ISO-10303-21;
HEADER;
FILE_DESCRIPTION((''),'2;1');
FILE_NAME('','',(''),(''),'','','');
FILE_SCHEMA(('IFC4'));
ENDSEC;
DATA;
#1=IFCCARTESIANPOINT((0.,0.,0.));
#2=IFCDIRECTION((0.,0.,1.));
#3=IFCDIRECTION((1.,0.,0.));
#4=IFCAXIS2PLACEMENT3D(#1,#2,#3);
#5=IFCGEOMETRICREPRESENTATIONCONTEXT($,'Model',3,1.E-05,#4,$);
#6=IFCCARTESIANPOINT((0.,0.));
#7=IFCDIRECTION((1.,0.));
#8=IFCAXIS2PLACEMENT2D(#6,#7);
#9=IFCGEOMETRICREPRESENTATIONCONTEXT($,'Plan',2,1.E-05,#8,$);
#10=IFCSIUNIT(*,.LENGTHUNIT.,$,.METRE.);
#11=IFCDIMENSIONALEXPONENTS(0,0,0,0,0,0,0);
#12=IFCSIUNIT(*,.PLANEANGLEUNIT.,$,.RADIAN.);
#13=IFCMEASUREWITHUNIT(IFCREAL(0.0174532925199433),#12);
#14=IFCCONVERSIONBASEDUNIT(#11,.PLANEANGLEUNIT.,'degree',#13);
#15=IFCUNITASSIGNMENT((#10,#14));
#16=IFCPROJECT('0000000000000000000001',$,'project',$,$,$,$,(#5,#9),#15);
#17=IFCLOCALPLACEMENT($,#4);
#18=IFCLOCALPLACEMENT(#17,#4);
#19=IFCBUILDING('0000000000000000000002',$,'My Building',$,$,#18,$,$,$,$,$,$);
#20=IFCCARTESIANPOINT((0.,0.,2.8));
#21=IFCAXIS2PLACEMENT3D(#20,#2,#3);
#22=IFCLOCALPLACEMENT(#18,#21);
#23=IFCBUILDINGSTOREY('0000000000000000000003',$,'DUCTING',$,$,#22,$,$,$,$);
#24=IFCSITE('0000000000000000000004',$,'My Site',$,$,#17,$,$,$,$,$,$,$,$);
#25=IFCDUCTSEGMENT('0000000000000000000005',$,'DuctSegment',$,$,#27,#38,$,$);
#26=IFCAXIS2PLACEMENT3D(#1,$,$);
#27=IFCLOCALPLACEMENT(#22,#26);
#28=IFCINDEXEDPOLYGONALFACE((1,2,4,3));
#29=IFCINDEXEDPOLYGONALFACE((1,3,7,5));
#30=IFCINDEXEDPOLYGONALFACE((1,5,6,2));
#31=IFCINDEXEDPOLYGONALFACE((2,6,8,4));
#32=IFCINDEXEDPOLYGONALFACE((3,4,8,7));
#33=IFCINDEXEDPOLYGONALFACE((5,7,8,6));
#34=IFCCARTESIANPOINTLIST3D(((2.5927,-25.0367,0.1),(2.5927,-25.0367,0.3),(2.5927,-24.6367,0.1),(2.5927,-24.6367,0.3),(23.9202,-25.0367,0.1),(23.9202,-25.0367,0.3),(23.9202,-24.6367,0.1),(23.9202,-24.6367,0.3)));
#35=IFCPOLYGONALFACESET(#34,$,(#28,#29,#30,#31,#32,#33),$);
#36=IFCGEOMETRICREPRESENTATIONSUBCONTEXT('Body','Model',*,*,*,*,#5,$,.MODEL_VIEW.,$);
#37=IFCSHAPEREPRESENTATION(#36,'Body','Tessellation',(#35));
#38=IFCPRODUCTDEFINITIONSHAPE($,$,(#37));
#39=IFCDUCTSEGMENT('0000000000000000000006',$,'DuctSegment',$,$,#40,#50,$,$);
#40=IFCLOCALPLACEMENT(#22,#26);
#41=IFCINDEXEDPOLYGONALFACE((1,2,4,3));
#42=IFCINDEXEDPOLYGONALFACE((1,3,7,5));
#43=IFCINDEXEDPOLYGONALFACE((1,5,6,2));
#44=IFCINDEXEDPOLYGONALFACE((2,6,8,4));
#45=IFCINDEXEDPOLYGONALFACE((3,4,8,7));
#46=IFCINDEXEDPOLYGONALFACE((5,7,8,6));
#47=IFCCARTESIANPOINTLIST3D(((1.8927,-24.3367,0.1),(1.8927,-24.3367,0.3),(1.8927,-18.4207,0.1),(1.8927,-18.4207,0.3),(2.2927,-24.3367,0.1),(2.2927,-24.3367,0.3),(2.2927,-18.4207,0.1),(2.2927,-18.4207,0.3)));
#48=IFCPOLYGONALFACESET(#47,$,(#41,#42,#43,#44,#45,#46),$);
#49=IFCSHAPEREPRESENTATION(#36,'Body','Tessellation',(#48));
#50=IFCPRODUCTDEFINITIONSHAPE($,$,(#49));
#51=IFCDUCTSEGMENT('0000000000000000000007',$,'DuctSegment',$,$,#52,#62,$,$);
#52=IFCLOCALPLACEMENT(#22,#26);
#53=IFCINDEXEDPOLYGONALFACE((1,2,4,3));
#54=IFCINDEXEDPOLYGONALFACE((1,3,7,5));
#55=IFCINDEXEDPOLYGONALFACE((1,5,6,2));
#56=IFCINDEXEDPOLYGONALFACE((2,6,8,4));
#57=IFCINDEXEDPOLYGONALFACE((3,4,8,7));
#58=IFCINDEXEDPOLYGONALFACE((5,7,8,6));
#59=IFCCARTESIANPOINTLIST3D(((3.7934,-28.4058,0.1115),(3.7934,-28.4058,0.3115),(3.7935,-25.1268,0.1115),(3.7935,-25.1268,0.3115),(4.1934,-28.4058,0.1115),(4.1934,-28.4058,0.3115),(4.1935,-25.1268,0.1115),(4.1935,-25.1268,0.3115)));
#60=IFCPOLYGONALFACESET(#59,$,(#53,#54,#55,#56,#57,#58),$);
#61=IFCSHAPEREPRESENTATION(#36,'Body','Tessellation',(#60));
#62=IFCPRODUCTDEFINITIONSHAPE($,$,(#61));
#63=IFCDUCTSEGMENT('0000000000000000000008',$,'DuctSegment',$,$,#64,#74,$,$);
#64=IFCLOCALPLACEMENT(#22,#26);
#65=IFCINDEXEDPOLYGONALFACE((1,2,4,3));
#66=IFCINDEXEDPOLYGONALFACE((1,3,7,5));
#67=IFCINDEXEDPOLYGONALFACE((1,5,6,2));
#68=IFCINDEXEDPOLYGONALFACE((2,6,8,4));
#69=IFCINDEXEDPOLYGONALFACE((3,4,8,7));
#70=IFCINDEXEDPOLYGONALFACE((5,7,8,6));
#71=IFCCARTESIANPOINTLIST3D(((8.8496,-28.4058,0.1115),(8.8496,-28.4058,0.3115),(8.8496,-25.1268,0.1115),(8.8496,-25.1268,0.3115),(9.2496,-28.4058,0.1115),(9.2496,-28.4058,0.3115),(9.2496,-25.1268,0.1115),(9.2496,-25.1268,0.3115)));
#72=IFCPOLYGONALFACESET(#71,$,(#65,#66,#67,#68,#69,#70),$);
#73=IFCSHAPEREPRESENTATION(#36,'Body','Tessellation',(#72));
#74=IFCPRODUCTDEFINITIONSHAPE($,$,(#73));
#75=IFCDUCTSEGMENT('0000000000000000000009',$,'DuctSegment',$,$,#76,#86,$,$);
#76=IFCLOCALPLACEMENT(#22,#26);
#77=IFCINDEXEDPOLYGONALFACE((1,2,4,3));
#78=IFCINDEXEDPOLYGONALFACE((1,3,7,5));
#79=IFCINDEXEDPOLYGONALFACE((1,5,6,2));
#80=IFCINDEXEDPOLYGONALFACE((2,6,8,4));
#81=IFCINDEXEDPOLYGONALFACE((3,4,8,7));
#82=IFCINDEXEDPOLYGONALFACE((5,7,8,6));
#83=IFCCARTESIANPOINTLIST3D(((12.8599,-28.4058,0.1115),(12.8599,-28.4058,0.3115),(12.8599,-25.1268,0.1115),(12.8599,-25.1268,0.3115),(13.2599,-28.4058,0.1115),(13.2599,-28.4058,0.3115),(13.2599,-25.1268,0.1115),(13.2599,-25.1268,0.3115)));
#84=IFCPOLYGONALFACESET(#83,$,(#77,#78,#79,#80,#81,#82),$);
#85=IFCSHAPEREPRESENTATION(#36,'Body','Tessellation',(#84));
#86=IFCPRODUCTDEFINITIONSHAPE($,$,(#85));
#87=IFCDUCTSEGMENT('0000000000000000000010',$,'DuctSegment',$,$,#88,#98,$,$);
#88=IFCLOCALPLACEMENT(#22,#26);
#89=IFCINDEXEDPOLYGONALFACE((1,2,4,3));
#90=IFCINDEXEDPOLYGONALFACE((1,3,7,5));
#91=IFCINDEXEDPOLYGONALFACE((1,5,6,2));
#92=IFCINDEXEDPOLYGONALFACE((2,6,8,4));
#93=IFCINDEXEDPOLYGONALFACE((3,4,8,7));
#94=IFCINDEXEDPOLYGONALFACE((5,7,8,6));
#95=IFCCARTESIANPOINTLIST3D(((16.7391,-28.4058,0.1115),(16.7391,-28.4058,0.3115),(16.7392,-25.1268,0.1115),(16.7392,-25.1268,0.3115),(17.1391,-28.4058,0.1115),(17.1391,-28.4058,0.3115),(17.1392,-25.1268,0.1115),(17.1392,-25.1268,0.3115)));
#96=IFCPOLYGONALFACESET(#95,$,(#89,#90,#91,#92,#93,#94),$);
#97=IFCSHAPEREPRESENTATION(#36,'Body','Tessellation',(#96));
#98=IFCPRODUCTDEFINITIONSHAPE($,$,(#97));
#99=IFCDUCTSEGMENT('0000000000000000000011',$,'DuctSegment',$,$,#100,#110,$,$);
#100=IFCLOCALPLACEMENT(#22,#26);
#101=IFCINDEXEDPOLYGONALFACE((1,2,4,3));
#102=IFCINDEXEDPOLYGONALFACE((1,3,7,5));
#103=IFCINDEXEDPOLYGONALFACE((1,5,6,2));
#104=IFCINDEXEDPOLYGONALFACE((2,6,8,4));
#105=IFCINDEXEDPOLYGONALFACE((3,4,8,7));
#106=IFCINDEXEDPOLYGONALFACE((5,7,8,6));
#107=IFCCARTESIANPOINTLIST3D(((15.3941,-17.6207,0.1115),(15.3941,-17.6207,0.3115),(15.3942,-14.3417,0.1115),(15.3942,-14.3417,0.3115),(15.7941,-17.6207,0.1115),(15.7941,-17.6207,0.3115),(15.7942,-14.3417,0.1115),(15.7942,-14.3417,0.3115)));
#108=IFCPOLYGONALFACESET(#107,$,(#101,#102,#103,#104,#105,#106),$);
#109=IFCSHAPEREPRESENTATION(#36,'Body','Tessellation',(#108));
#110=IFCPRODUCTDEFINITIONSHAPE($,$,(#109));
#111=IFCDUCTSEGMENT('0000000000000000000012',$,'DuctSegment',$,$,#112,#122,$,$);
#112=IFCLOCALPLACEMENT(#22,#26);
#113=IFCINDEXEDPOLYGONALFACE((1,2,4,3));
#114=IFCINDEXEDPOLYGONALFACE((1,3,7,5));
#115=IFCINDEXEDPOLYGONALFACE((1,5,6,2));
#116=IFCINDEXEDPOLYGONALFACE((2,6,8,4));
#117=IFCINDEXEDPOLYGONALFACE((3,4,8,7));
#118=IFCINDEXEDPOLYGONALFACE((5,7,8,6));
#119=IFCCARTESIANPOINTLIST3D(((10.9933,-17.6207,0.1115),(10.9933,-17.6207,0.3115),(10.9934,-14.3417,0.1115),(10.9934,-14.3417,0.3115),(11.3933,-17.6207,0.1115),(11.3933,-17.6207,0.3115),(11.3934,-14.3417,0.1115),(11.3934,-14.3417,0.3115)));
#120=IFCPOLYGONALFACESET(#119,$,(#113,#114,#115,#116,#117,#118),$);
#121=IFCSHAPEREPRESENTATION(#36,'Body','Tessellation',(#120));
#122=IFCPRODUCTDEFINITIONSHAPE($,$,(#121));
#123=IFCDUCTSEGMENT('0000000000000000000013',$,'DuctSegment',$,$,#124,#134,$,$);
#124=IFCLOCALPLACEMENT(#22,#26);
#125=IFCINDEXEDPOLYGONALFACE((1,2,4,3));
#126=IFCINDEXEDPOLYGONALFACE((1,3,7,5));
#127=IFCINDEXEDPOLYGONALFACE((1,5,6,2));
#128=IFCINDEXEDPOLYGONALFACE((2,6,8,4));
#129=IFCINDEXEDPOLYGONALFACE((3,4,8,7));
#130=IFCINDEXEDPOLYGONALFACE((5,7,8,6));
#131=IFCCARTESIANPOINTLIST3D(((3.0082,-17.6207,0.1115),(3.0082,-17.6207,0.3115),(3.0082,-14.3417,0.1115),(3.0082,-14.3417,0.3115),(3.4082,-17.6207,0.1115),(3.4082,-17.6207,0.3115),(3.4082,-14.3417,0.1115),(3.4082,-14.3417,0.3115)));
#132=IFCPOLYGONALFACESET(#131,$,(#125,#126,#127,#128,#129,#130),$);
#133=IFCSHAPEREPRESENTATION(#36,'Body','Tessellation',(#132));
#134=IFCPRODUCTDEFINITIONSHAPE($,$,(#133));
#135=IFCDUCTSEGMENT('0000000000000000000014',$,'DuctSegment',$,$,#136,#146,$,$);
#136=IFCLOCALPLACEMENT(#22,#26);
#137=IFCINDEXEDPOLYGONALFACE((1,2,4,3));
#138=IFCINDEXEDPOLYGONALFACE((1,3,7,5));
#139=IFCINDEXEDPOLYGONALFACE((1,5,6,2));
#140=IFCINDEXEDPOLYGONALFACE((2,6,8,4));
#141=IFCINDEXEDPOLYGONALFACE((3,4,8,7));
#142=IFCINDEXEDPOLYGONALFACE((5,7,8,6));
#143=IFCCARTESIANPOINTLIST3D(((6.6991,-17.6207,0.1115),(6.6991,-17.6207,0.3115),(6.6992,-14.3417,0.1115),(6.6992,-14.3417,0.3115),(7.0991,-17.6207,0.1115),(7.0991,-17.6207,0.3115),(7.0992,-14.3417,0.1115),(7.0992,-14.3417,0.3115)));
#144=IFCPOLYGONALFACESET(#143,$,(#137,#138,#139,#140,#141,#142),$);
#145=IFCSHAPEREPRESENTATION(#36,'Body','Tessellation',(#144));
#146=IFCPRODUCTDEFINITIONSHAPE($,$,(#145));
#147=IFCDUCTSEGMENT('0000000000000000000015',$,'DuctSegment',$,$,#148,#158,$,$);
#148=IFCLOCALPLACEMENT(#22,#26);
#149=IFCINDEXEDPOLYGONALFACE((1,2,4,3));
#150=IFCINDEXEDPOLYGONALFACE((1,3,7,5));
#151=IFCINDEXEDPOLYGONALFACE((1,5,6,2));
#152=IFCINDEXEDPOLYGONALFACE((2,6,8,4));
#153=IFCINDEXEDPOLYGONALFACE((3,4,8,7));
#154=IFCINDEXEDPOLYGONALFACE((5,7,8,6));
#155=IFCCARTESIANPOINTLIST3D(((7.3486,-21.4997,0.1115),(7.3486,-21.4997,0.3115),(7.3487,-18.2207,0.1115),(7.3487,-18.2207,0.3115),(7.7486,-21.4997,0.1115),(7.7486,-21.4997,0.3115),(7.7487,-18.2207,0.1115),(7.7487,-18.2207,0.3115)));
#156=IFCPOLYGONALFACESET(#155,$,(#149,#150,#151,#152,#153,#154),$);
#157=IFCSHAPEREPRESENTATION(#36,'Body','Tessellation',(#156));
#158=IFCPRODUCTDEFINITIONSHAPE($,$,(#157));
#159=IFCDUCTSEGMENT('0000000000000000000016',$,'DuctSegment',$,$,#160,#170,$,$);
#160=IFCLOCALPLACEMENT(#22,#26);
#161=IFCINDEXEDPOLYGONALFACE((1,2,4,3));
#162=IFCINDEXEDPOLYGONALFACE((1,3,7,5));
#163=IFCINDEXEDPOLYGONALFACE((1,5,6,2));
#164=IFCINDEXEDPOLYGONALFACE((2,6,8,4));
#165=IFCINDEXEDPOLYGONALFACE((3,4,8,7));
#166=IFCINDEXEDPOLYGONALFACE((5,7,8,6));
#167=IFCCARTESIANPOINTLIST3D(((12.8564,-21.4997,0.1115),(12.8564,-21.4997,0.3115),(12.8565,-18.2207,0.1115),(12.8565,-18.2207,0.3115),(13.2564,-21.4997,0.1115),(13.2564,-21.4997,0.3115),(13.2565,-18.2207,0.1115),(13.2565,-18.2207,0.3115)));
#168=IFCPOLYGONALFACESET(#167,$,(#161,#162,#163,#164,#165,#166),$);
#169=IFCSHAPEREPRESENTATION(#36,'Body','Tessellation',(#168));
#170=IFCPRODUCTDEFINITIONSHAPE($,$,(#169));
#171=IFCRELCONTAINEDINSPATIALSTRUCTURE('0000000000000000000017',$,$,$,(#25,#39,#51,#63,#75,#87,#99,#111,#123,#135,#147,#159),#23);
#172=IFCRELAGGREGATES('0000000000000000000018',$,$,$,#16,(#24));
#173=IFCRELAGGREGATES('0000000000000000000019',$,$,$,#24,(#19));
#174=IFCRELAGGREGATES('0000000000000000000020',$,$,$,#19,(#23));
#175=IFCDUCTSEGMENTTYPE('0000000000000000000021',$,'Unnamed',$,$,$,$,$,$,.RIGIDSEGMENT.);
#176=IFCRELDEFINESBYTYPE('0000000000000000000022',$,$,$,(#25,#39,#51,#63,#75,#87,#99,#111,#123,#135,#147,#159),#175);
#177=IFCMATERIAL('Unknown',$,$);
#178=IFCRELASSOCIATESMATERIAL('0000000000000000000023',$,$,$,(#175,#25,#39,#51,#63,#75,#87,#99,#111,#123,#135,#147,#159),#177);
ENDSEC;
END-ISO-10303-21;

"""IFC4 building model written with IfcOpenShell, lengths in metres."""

from ifc_helpers import new_model, entity, si_unit, converted_unit, frame, origin_with_axes, origin_2d_with_axis, place, context, subcontext, project, spatial, rectangle, extrude, material, material_profile, profile_set, profile_usage, type_object, element, save


model = new_model("IFC4")

# Units and contexts
model_context = context("Model", 3, precision=1e-05, world=origin_with_axes())
plan_context = context("Plan", 2, precision=1e-05, world=origin_2d_with_axis())
body_context = subcontext(model_context, "Body", "Model", "MODEL_VIEW")
ifc_project = project(units=[si_unit("LENGTHUNIT", "METRE"), converted_unit("PLANEANGLEUNIT", "degree", entity("IfcReal", 0.0174532925199433), si_unit("PLANEANGLEUNIT", "RADIAN"), dimensions=[0, 0, 0, 0, 0, 0, 0])], contexts=[model_context, plan_context])

# Site, building, storey
site_placement = place(None, origin_with_axes())
site = spatial("IfcSite", under=ifc_project, at=site_placement, Name="My Site")
building_placement = place(site_placement, origin_with_axes())
building = spatial("IfcBuilding", under=site, at=building_placement, Name="My Building")
storey_placement = place(building_placement, frame((0.0, 0.0, 2.8), z_axis=(0.0, 0.0, 1.0), x_axis=(1.0, 0.0, 0.0)))
storey = spatial("IfcBuildingStorey", under=building, at=storey_placement, Name="DUCTING")

# Duct segments
ifc_material = material(Name="Unknown")
ifc_material_profile_1 = material_profile(ifc_material, rectangle(XDim=0.4, YDim=0.2))
ifc_profile_set_1 = profile_set([ifc_material_profile_1])
ifc_profile_usage_1 = profile_usage(ifc_profile_set_1, cardinal=5)
duct_segment_type = type_object("IfcDuctSegmentType", Name="Unnamed", PredefinedType="RIGIDSEGMENT", material=ifc_profile_set_1)
duct_segment_1_placement = place(storey_placement, frame((2.5927, -24.8367, 0.2), z_axis=(1.0, 0.0, 0.0), x_axis=(0.0, 1.0, 0.0)))
element("IfcDuctSegment", 1, at=duct_segment_1_placement, inside=storey, type_object=duct_segment_type, material=ifc_profile_usage_1, Name="DuctSegment", context=body_context, shape_type="SweptSolid", body=[
    extrude(rectangle(XDim=0.4, YDim=0.2), origin_with_axes(), (0.0, 0.0, 1.0), 21.3274),
])
ifc_profile_usage_2 = profile_usage(ifc_profile_set_1, cardinal=5)
duct_segment_2_placement = place(storey_placement, frame((2.0927, -24.3367, 0.2), z_axis=(0.0, 1.0, 0.0), x_axis=(-1.0, 0.0, 0.0)))
element("IfcDuctSegment", 2, at=duct_segment_2_placement, inside=storey, type_object=duct_segment_type, material=ifc_profile_usage_2, Name="DuctSegment", context=body_context, shape_type="SweptSolid", body=[
    extrude(rectangle(XDim=0.4, YDim=0.2), origin_with_axes(), (0.0, 0.0, 1.0), 5.916),
])
ifc_profile_usage_3 = profile_usage(ifc_profile_set_1, cardinal=5)
duct_segment_3_placement = place(storey_placement, frame((3.9935, -25.1268, 0.2115), z_axis=(-0.000018, -1.0, 0.000001), x_axis=(1.0, -0.000018, 0.0)))
element("IfcDuctSegment", 3, at=duct_segment_3_placement, inside=storey, type_object=duct_segment_type, material=ifc_profile_usage_3, Name="DuctSegment", context=body_context, shape_type="SweptSolid", body=[
    extrude(rectangle(XDim=0.4, YDim=0.2), origin_with_axes(), (0.0, 0.0, 1.0), 3.279),
])
ifc_profile_usage_4 = profile_usage(ifc_profile_set_1, cardinal=5)
duct_segment_4_placement = place(storey_placement, frame((9.0496, -25.1268, 0.2115), z_axis=(-0.000018, -1.0, 0.000001), x_axis=(1.0, -0.000018, 0.0)))
element("IfcDuctSegment", 4, at=duct_segment_4_placement, inside=storey, type_object=duct_segment_type, material=ifc_profile_usage_4, Name="DuctSegment", context=body_context, shape_type="SweptSolid", body=[
    extrude(rectangle(XDim=0.4, YDim=0.2), origin_with_axes(), (0.0, 0.0, 1.0), 3.279),
])
ifc_profile_usage_5 = profile_usage(ifc_profile_set_1, cardinal=5)
duct_segment_5_placement = place(storey_placement, frame((13.0599, -25.1268, 0.2115), z_axis=(-0.000018, -1.0, 0.000001), x_axis=(1.0, -0.000018, 0.0)))
element("IfcDuctSegment", 5, at=duct_segment_5_placement, inside=storey, type_object=duct_segment_type, material=ifc_profile_usage_5, Name="DuctSegment", context=body_context, shape_type="SweptSolid", body=[
    extrude(rectangle(XDim=0.4, YDim=0.2), origin_with_axes(), (0.0, 0.0, 1.0), 3.279),
])
ifc_profile_usage_6 = profile_usage(ifc_profile_set_1, cardinal=5)
duct_segment_6_placement = place(storey_placement, frame((16.9392, -25.1268, 0.2115), z_axis=(-0.000018, -1.0, 0.000001), x_axis=(1.0, -0.000018, 0.0)))
element("IfcDuctSegment", 6, at=duct_segment_6_placement, inside=storey, type_object=duct_segment_type, material=ifc_profile_usage_6, Name="DuctSegment", context=body_context, shape_type="SweptSolid", body=[
    extrude(rectangle(XDim=0.4, YDim=0.2), origin_with_axes(), (0.0, 0.0, 1.0), 3.279),
])
ifc_profile_usage_7 = profile_usage(ifc_profile_set_1, cardinal=5)
duct_segment_7_placement = place(storey_placement, frame((15.5941, -17.6207, 0.2115), z_axis=(0.000025, 1.0, 0.000001), x_axis=(-1.0, 0.000025, 0.0)))
element("IfcDuctSegment", 7, at=duct_segment_7_placement, inside=storey, type_object=duct_segment_type, material=ifc_profile_usage_7, Name="DuctSegment", context=body_context, shape_type="SweptSolid", body=[
    extrude(rectangle(XDim=0.4, YDim=0.2), origin_with_axes(), (0.0, 0.0, 1.0), 3.279),
])
ifc_profile_usage_8 = profile_usage(ifc_profile_set_1, cardinal=5)
duct_segment_8_placement = place(storey_placement, frame((11.1933, -17.6207, 0.2115), z_axis=(0.000025, 1.0, 0.000001), x_axis=(-1.0, 0.000025, 0.0)))
element("IfcDuctSegment", 8, at=duct_segment_8_placement, inside=storey, type_object=duct_segment_type, material=ifc_profile_usage_8, Name="DuctSegment", context=body_context, shape_type="SweptSolid", body=[
    extrude(rectangle(XDim=0.4, YDim=0.2), origin_with_axes(), (0.0, 0.0, 1.0), 3.279),
])
ifc_profile_usage_9 = profile_usage(ifc_profile_set_1, cardinal=5)
duct_segment_9_placement = place(storey_placement, frame((3.2082, -17.6207, 0.2115), z_axis=(0.000025, 1.0, 0.000001), x_axis=(-1.0, 0.000025, 0.0)))
element("IfcDuctSegment", 9, at=duct_segment_9_placement, inside=storey, type_object=duct_segment_type, material=ifc_profile_usage_9, Name="DuctSegment", context=body_context, shape_type="SweptSolid", body=[
    extrude(rectangle(XDim=0.4, YDim=0.2), origin_with_axes(), (0.0, 0.0, 1.0), 3.279),
])
ifc_profile_usage_10 = profile_usage(ifc_profile_set_1, cardinal=5)
duct_segment_10_placement = place(storey_placement, frame((6.8991, -17.6207, 0.2115), z_axis=(0.000025, 1.0, 0.000001), x_axis=(-1.0, 0.000025, 0.0)))
element("IfcDuctSegment", 10, at=duct_segment_10_placement, inside=storey, type_object=duct_segment_type, material=ifc_profile_usage_10, Name="DuctSegment", context=body_context, shape_type="SweptSolid", body=[
    extrude(rectangle(XDim=0.4, YDim=0.2), origin_with_axes(), (0.0, 0.0, 1.0), 3.279),
])
ifc_profile_usage_11 = profile_usage(ifc_profile_set_1, cardinal=5)
duct_segment_11_placement = place(storey_placement, frame((7.5487, -18.2207, 0.2115), z_axis=(-0.000018, -1.0, 0.000001), x_axis=(1.0, -0.000018, 0.0)))
element("IfcDuctSegment", 11, at=duct_segment_11_placement, inside=storey, type_object=duct_segment_type, material=ifc_profile_usage_11, Name="DuctSegment", context=body_context, shape_type="SweptSolid", body=[
    extrude(rectangle(XDim=0.4, YDim=0.2), origin_with_axes(), (0.0, 0.0, 1.0), 3.279),
])
ifc_profile_usage_12 = profile_usage(ifc_profile_set_1, cardinal=5)
duct_segment_12_placement = place(storey_placement, frame((13.0565, -18.2207, 0.2115), z_axis=(-0.000018, -1.0, 0.000001), x_axis=(1.0, -0.000018, 0.0)))
element("IfcDuctSegment", 12, at=duct_segment_12_placement, inside=storey, type_object=duct_segment_type, material=ifc_profile_usage_12, Name="DuctSegment", context=body_context, shape_type="SweptSolid", body=[
    extrude(rectangle(XDim=0.4, YDim=0.2), origin_with_axes(), (0.0, 0.0, 1.0), 3.279),
])

save(model, "model.ifc")
